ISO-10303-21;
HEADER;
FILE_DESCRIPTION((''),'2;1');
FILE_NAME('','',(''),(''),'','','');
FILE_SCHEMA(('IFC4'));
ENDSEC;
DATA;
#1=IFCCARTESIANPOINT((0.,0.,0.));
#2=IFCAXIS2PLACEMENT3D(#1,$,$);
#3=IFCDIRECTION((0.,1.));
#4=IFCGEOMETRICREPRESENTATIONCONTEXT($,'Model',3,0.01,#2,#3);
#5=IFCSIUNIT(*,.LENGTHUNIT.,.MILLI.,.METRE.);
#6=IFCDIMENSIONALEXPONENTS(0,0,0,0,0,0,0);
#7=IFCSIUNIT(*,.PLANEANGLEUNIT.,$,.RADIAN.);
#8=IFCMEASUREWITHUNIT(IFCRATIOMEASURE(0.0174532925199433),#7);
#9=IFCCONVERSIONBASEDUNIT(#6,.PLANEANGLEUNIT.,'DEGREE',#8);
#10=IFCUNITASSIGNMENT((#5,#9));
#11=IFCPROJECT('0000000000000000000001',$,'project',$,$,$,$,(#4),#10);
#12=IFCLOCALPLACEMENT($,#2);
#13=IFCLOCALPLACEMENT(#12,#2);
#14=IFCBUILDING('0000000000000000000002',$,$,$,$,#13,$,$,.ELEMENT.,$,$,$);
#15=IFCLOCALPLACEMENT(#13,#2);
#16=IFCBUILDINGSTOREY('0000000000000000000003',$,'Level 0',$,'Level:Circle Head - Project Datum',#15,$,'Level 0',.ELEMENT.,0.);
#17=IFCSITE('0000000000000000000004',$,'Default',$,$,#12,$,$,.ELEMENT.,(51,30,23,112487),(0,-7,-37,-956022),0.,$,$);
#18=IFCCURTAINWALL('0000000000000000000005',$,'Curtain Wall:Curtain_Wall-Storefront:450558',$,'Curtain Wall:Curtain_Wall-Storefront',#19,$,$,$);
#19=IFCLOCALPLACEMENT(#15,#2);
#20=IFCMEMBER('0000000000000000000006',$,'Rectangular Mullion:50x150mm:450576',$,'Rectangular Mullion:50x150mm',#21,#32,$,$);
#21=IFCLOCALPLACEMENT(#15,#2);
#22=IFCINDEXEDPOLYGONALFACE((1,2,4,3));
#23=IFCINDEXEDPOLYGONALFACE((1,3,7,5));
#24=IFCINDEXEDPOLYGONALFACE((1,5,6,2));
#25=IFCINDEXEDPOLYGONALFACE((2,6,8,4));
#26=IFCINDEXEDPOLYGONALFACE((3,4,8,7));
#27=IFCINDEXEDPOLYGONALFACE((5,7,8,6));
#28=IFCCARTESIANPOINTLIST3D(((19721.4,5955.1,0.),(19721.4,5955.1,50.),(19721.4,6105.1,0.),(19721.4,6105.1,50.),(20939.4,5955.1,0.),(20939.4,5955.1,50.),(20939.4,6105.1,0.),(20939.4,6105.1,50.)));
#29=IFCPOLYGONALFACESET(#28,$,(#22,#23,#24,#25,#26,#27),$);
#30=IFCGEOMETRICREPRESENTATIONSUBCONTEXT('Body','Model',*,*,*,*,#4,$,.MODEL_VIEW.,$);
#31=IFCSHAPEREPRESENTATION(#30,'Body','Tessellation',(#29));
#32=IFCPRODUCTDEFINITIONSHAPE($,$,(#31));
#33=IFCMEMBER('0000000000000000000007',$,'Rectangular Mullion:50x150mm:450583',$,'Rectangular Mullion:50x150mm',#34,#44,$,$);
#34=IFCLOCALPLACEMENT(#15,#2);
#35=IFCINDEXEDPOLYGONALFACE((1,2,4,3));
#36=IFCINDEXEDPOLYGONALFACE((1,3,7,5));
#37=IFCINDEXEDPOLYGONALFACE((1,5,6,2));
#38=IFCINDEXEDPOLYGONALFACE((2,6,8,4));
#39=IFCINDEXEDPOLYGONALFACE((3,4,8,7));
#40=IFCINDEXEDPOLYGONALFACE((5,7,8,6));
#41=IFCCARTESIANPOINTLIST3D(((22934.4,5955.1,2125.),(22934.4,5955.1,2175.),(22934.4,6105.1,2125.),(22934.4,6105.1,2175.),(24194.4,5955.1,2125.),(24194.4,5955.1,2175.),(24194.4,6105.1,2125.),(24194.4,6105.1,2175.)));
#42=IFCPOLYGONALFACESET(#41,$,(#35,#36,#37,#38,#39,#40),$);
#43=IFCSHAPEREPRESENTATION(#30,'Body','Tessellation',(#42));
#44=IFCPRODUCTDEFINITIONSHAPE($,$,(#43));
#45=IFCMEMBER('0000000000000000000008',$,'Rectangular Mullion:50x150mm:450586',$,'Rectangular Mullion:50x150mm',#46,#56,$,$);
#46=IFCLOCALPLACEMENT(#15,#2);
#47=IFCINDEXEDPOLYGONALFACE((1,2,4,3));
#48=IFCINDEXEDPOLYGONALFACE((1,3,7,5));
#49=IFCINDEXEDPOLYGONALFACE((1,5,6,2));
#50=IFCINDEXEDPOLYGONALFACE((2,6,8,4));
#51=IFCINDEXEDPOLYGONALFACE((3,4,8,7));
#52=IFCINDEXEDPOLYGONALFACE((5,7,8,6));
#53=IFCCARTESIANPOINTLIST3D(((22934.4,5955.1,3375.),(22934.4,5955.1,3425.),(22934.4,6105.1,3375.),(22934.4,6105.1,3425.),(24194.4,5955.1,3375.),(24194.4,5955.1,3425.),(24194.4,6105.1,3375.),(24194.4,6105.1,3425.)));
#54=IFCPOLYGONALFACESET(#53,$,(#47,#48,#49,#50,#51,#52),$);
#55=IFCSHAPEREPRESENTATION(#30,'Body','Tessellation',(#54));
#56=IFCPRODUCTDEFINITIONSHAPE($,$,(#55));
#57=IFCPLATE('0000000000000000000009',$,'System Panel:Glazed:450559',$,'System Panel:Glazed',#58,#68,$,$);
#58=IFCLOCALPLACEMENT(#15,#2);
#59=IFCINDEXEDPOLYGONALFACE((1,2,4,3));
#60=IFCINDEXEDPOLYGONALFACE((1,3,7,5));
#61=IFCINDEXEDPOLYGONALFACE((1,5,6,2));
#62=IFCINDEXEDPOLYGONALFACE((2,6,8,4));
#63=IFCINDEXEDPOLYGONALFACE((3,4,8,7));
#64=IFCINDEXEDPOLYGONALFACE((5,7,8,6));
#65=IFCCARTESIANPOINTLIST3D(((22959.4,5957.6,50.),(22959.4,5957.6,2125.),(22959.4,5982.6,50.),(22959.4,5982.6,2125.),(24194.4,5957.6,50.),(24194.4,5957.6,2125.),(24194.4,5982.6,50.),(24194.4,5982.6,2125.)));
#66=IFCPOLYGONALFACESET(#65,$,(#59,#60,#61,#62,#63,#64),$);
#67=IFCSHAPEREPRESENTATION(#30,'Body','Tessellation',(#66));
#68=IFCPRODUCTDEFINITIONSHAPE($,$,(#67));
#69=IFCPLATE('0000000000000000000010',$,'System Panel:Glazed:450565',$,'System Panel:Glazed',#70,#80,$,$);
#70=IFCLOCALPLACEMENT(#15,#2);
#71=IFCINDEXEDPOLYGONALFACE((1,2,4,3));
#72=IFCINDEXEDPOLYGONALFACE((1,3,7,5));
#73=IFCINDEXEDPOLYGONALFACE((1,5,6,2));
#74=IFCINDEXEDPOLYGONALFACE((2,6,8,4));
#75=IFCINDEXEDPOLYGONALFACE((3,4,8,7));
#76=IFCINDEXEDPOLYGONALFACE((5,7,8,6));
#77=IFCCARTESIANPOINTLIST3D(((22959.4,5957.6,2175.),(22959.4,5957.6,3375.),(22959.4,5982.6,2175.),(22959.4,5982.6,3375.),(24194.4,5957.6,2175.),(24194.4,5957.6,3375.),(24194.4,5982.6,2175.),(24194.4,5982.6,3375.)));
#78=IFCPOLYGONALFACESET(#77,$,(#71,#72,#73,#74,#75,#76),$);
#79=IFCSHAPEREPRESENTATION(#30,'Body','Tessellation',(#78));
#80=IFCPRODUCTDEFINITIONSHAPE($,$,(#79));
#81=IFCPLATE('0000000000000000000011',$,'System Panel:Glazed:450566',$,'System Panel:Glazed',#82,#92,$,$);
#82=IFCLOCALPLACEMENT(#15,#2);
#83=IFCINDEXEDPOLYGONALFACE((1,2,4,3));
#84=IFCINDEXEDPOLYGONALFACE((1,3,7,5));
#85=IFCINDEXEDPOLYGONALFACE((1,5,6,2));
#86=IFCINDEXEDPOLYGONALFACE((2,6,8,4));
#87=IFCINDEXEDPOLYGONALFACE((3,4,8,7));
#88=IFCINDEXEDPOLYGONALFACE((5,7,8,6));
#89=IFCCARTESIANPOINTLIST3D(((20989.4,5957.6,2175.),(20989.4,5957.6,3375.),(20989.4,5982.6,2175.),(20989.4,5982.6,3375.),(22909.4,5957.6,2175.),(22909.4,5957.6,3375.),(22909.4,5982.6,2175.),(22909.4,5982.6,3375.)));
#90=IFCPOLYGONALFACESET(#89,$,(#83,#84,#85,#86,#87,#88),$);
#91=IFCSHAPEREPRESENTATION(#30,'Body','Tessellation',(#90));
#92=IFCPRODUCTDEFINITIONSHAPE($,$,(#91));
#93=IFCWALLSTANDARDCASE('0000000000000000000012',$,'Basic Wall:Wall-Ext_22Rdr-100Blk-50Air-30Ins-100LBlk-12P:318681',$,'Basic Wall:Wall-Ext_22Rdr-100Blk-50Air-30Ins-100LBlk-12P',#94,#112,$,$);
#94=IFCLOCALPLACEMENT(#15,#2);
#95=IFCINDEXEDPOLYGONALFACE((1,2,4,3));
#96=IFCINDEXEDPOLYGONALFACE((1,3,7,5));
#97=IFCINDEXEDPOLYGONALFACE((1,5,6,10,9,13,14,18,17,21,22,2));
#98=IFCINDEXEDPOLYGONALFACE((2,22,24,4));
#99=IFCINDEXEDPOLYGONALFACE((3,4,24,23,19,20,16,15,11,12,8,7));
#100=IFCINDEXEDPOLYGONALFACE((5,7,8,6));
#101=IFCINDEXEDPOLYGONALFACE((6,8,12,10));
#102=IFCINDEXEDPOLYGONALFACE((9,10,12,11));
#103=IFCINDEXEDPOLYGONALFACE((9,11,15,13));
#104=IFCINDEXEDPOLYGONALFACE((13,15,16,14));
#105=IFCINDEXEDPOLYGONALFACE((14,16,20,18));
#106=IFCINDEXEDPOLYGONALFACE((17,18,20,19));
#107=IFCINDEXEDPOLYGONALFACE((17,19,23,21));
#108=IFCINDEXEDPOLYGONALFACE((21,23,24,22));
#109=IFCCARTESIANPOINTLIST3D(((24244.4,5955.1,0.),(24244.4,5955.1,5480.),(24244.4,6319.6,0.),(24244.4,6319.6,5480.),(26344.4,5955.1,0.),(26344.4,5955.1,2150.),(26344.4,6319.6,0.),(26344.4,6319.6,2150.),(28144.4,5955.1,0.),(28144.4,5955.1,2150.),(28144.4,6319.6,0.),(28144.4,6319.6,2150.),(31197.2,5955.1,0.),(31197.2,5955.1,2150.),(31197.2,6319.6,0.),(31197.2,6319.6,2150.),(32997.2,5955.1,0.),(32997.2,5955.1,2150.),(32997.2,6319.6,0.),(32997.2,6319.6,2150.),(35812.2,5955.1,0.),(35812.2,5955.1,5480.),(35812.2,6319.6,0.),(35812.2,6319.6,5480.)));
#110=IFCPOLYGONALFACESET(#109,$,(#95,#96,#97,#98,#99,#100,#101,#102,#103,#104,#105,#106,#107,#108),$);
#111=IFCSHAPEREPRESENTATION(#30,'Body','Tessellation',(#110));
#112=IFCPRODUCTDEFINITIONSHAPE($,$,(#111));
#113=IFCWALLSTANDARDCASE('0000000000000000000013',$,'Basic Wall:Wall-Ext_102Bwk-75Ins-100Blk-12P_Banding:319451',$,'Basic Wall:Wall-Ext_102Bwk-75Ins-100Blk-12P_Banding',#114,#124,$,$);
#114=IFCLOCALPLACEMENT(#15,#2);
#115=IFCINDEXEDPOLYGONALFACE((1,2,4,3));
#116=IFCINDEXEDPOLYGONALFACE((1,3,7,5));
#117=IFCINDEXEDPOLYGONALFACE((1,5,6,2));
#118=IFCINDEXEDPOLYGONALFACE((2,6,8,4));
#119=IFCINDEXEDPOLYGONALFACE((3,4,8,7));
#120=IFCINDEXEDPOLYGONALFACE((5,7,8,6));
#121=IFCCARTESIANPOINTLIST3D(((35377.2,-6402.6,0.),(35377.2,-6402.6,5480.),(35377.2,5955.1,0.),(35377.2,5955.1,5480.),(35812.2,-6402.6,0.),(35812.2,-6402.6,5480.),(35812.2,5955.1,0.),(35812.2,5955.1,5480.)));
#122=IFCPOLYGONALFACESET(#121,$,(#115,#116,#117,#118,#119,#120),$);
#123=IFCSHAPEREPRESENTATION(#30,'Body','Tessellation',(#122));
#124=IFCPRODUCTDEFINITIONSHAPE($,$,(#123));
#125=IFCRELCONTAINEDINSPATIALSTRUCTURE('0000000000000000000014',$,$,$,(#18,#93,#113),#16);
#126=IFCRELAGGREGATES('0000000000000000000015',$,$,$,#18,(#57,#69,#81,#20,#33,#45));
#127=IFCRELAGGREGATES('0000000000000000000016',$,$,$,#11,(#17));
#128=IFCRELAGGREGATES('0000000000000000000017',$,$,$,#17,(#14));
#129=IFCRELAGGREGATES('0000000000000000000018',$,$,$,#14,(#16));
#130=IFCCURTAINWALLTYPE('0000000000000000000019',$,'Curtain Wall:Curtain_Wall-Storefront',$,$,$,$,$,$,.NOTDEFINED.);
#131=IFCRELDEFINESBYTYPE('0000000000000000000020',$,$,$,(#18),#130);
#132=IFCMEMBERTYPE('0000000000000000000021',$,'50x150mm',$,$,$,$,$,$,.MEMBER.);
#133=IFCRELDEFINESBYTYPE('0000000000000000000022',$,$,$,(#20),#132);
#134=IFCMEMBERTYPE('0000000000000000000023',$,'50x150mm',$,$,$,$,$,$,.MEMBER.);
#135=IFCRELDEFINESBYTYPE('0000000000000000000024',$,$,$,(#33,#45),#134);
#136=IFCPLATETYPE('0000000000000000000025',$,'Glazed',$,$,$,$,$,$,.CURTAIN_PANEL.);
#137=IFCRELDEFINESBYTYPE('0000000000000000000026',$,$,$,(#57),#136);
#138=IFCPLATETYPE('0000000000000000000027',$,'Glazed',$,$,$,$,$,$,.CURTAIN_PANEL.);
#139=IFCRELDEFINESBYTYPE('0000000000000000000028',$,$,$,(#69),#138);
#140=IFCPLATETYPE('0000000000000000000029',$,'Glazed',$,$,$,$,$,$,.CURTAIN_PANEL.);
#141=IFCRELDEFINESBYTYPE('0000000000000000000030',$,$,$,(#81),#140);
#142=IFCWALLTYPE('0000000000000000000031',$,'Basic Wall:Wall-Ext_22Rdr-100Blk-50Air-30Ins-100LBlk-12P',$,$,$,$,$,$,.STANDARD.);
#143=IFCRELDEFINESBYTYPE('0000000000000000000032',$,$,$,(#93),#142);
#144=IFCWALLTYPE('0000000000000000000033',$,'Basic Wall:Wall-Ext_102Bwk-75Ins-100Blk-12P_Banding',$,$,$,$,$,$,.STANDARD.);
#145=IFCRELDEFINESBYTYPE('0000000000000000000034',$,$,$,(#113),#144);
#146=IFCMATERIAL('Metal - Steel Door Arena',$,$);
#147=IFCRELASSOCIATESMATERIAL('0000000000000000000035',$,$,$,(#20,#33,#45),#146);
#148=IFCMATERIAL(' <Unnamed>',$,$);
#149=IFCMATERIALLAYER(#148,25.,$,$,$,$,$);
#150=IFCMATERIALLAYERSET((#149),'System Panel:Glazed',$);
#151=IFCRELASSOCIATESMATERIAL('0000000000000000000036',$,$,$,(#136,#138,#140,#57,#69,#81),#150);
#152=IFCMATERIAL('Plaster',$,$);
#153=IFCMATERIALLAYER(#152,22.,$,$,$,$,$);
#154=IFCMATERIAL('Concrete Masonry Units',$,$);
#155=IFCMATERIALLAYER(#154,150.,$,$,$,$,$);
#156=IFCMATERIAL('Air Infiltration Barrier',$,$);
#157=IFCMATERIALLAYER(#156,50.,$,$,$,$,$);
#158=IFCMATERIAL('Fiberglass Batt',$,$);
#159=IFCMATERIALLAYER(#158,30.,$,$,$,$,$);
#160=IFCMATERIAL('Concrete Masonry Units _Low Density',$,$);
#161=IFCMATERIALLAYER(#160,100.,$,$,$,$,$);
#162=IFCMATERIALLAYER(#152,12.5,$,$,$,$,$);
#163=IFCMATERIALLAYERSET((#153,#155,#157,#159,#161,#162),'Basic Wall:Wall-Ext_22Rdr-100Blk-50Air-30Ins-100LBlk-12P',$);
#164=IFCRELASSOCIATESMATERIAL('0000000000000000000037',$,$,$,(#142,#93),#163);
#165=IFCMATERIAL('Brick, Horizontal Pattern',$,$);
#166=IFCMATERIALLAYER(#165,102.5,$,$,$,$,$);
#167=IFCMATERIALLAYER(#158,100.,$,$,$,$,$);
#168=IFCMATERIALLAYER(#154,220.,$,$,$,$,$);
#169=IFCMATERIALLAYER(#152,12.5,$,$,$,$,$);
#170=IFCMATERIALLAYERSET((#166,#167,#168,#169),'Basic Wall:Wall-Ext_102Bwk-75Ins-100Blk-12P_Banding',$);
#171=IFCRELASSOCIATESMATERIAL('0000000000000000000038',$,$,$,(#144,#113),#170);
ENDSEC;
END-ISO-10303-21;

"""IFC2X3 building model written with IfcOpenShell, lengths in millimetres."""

from ifc_helpers import new_model, entity, si_unit, converted_unit, direction, frame, frame_2d, origin, origin_2d_with_axis, place, context, subcontext, project, spatial, rectangle, extrude, source, transform, mapped, material, layer, layer_set, layer_usage, type_object, type_shapes, element, aggregate, save


model = new_model("IFC2X3")

# Units and contexts
model_context = context("Model", 3, precision=0.01, world=origin(), true_north=direction((0.0, 1.0)))
body_context = subcontext(model_context, "Body", "Model", "MODEL_VIEW")
ifc_project = project(units=[si_unit("LENGTHUNIT", "METRE", prefix="MILLI"), converted_unit("PLANEANGLEUNIT", "DEGREE", entity("IfcRatioMeasure", 0.0174532925199433), si_unit("PLANEANGLEUNIT", "RADIAN"), dimensions=[0, 0, 0, 0, 0, 0, 0])], contexts=[model_context])

# Site, building, storey
site_placement = place(None, origin())
site = spatial("IfcSite", under=ifc_project, at=site_placement, Name="Default", CompositionType="ELEMENT", RefLatitude=(51, 30, 23, 112487), RefLongitude=(0, -7, -37, -956022), RefElevation=0.0)
building_placement = place(site_placement, origin())
building = spatial("IfcBuilding", under=site, at=building_placement, CompositionType="ELEMENT")
storey_placement = place(building_placement, origin())
storey = spatial("IfcBuildingStorey", under=building, at=storey_placement, Name="Level 0", ObjectType="Level:Circle Head - Project Datum", LongName="Level 0", CompositionType="ELEMENT", Elevation=0.0)

# Curtain wall, members, plates
curtain_wall_type = type_object("IfcCurtainWallType", Name="Curtain Wall:Curtain_Wall-Storefront", PredefinedType="NOTDEFINED")
curtain_wall_placement = place(storey_placement, origin())
curtain_wall = element("IfcCurtainWall", 1, at=curtain_wall_placement, inside=storey, type_object=curtain_wall_type, Name="Curtain Wall:Curtain_Wall-Storefront:450558", ObjectType="Curtain Wall:Curtain_Wall-Storefront")
ifc_material_1 = material(Name="Metal - Steel Door Arena")
member_type_1 = type_object("IfcMemberType", Name="50x150mm", PredefinedType="MEMBER")
shared_shape_1 = source(origin(), body_context, "Body", "SweptSolid", [
    extrude(rectangle(XDim=150.0, YDim=50.0, at=origin_2d_with_axis()), frame((-25.0, 0.0, -1218.0), z_axis=(0.0, 0.0, 1.0), x_axis=(0.0, -1.0, 0.0)), (0.0, 0.0, 1.0), 1218.0),
])
type_shapes(member_type_1, [shared_shape_1])
member_1_placement = place(storey_placement, frame((20939.4, 6030.1, 0.0), z_axis=(1.0, 0.0, 0.0), x_axis=(0.0, 0.0, -1.0)))
member_1 = element("IfcMember", 2, at=member_1_placement, type_object=member_type_1, material=ifc_material_1, Name="Rectangular Mullion:50x150mm:450576", ObjectType="Rectangular Mullion:50x150mm", context=body_context, shape_type="MappedRepresentation", body=[
    mapped(shared_shape_1, transform((0.0, 0.0, 0.0), scale=1.0)),
])
member_type_2 = type_object("IfcMemberType", Name="50x150mm", PredefinedType="MEMBER")
shared_shape_2 = source(origin(), body_context, "Body", "SweptSolid", [
    extrude(rectangle(XDim=150.0, YDim=50.0, at=origin_2d_with_axis()), frame((0.0, 0.0, -1260.0), z_axis=(0.0, 0.0, 1.0), x_axis=(0.0, -1.0, 0.0)), (0.0, 0.0, 1.0), 1260.0),
])
type_shapes(member_type_2, [shared_shape_2])
member_2_placement = place(storey_placement, frame((22934.4, 6030.1, 2150.0), z_axis=(-1.0, 0.0, 0.0), x_axis=(0.0, 0.0, 1.0)))
member_2 = element("IfcMember", 3, at=member_2_placement, type_object=member_type_2, material=ifc_material_1, Name="Rectangular Mullion:50x150mm:450583", ObjectType="Rectangular Mullion:50x150mm", context=body_context, shape_type="MappedRepresentation", body=[
    mapped(shared_shape_2, transform((0.0, 0.0, 0.0), scale=1.0)),
])
member_3_placement = place(storey_placement, frame((22934.4, 6030.1, 3400.0), z_axis=(-1.0, 0.0, 0.0), x_axis=(0.0, 0.0, 1.0)))
member_3 = element("IfcMember", 4, at=member_3_placement, type_object=member_type_2, material=ifc_material_1, Name="Rectangular Mullion:50x150mm:450586", ObjectType="Rectangular Mullion:50x150mm", context=body_context, shape_type="MappedRepresentation", body=[
    mapped(shared_shape_2, transform((0.0, 0.0, 0.0), scale=1.0)),
])
ifc_material_2 = material(Name=" <Unnamed>")
ifc_layer_1 = layer(ifc_material_2, 25.0)
ifc_layer_set_1 = layer_set([ifc_layer_1], Name="System Panel:Glazed")
ifc_layer_usage_1 = layer_usage(ifc_layer_set_1, "AXIS3", "POSITIVE", 0.2)
plate_type_1 = type_object("IfcPlateType", Name="Glazed", PredefinedType="CURTAIN_PANEL", material=ifc_layer_set_1)
shared_shape_3 = source(origin(), body_context, "Body", "SweptSolid", [
    extrude(rectangle(XDim=25.0, YDim=1235.0, at=origin_2d_with_axis()), frame((0.0, 60.0, 0.0), z_axis=(0.0, 0.0, 1.0), x_axis=(0.0, 1.0, 0.0)), (0.0, 0.0, 1.0), 2075.0),
])
type_shapes(plate_type_1, [shared_shape_3])
plate_1_placement = place(curtain_wall_placement, frame((23576.9, 6030.1, 50.0), z_axis=(0.0, 0.0, 1.0), x_axis=(-1.0, 0.0, 0.0)))
plate_1 = element("IfcPlate", 5, at=plate_1_placement, type_object=plate_type_1, material=ifc_layer_usage_1, Name="System Panel:Glazed:450559", ObjectType="System Panel:Glazed", context=body_context, shape_type="MappedRepresentation", body=[
    mapped(shared_shape_3, transform((0.0, 0.0, 0.0), scale=1.0)),
])
ifc_layer_usage_2 = layer_usage(ifc_layer_set_1, "AXIS3", "POSITIVE", 0.2)
plate_type_2 = type_object("IfcPlateType", Name="Glazed", PredefinedType="CURTAIN_PANEL", material=ifc_layer_set_1)
shared_shape_4 = source(origin(), body_context, "Body", "SweptSolid", [
    extrude(rectangle(XDim=25.0, YDim=1235.0, at=origin_2d_with_axis()), frame((0.0, 60.0, 0.0), z_axis=(0.0, 0.0, 1.0), x_axis=(0.0, 1.0, 0.0)), (0.0, 0.0, 1.0), 1200.0),
])
type_shapes(plate_type_2, [shared_shape_4])
plate_2_placement = place(curtain_wall_placement, frame((23576.9, 6030.1, 2175.0), z_axis=(0.0, 0.0, 1.0), x_axis=(-1.0, 0.0, 0.0)))
plate_2 = element("IfcPlate", 6, at=plate_2_placement, type_object=plate_type_2, material=ifc_layer_usage_2, Name="System Panel:Glazed:450565", ObjectType="System Panel:Glazed", context=body_context, shape_type="MappedRepresentation", body=[
    mapped(shared_shape_4, transform((0.0, 0.0, 0.0), scale=1.0)),
])
ifc_layer_usage_3 = layer_usage(ifc_layer_set_1, "AXIS3", "POSITIVE", 0.2)
plate_type_3 = type_object("IfcPlateType", Name="Glazed", PredefinedType="CURTAIN_PANEL", material=ifc_layer_set_1)
shared_shape_5 = source(origin(), body_context, "Body", "SweptSolid", [
    extrude(rectangle(XDim=25.0, YDim=1920.0, at=origin_2d_with_axis()), frame((0.0, 60.0, 0.0), z_axis=(0.0, 0.0, 1.0), x_axis=(0.0, 1.0, 0.0)), (0.0, 0.0, 1.0), 1200.0),
])
type_shapes(plate_type_3, [shared_shape_5])
plate_3_placement = place(curtain_wall_placement, frame((21949.4, 6030.1, 2175.0), z_axis=(0.0, 0.0, 1.0), x_axis=(-1.0, 0.0, 0.0)))
plate_3 = element("IfcPlate", 7, at=plate_3_placement, type_object=plate_type_3, material=ifc_layer_usage_3, Name="System Panel:Glazed:450566", ObjectType="System Panel:Glazed", context=body_context, shape_type="MappedRepresentation", body=[
    mapped(shared_shape_5, transform((0.0, 0.0, 0.0), scale=1.0)),
])
aggregate(curtain_wall, [plate_1, plate_2, plate_3, member_1, member_2, member_3])

# Wall, openings
ifc_material_3 = material(Name="Plaster")
ifc_layer_2 = layer(ifc_material_3, 22.0)
ifc_material_4 = material(Name="Concrete Masonry Units")
ifc_layer_3 = layer(ifc_material_4, 150.0)
ifc_material_5 = material(Name="Air Infiltration Barrier")
ifc_layer_4 = layer(ifc_material_5, 50.0)
ifc_material_6 = material(Name="Fiberglass Batt")
ifc_layer_5 = layer(ifc_material_6, 30.0)
ifc_material_7 = material(Name="Concrete Masonry Units _Low Density")
ifc_layer_6 = layer(ifc_material_7, 100.0)
ifc_layer_7 = layer(ifc_material_3, 12.5)
ifc_layer_set_2 = layer_set([ifc_layer_2, ifc_layer_3, ifc_layer_4, ifc_layer_5, ifc_layer_6, ifc_layer_7], Name="Basic Wall:Wall-Ext_22Rdr-100Blk-50Air-30Ins-100LBlk-12P")
ifc_layer_usage_4 = layer_usage(ifc_layer_set_2, "AXIS2", "NEGATIVE", 182.2)
wall_type_1 = type_object("IfcWallType", Name="Basic Wall:Wall-Ext_22Rdr-100Blk-50Air-30Ins-100LBlk-12P", PredefinedType="STANDARD", material=ifc_layer_set_2)
wall_1_placement = place(storey_placement, frame((35812.2, 6137.4, 0.0), z_axis=(0.0, 0.0, 1.0), x_axis=(-1.0, 0.0, 0.0)))
wall_1 = element("IfcWallStandardCase", 8, at=wall_1_placement, inside=storey, type_object=wall_type_1, material=ifc_layer_usage_4, Name="Basic Wall:Wall-Ext_22Rdr-100Blk-50Air-30Ins-100LBlk-12P:318681", ObjectType="Basic Wall:Wall-Ext_22Rdr-100Blk-50Air-30Ins-100LBlk-12P", context=body_context, shape_type="SweptSolid", body=[
    extrude(rectangle(XDim=11567.8, YDim=364.5, at=frame_2d((5783.9, 0.0), x_axis=(-1.0, 0.0))), origin(), (0.0, 0.0, 1.0), 5480.0),
])
opening_1_placement = place(wall_1_placement, frame((9467.7, 182.2, 0.0)))
element("IfcOpeningElement", 9, at=opening_1_placement, cuts=wall_1, ObjectType="Opening", context=body_context, shape_type="SweptSolid", body=[
    extrude(rectangle(XDim=2150.0, YDim=1800.0, at=frame_2d((1075.0, 900.0), x_axis=(1.0, 0.0))), frame((0.0, 0.0, 0.0), z_axis=(0.0, -1.0, 0.0), x_axis=(0.0, 0.0, 1.0)), (0.0, 0.0, 1.0), 364.5),
])
opening_2_placement = place(wall_1_placement, frame((4615.0, 182.2, 0.0)))
element("IfcOpeningElement", 10, at=opening_2_placement, cuts=wall_1, ObjectType="Opening", context=body_context, shape_type="SweptSolid", body=[
    extrude(rectangle(XDim=2150.0, YDim=1800.0, at=frame_2d((1075.0, 900.0), x_axis=(1.0, 0.0))), frame((0.0, 0.0, 0.0), z_axis=(0.0, -1.0, 0.0), x_axis=(0.0, 0.0, 1.0)), (0.0, 0.0, 1.0), 364.5),
])

# Wall
ifc_material_8 = material(Name="Brick, Horizontal Pattern")
ifc_layer_8 = layer(ifc_material_8, 102.5)
ifc_layer_9 = layer(ifc_material_6, 100.0)
ifc_layer_10 = layer(ifc_material_4, 220.0)
ifc_layer_11 = layer(ifc_material_3, 12.5)
ifc_layer_set_3 = layer_set([ifc_layer_8, ifc_layer_9, ifc_layer_10, ifc_layer_11], Name="Basic Wall:Wall-Ext_102Bwk-75Ins-100Blk-12P_Banding")
ifc_layer_usage_5 = layer_usage(ifc_layer_set_3, "AXIS2", "NEGATIVE", 217.5)
wall_type_2 = type_object("IfcWallType", Name="Basic Wall:Wall-Ext_102Bwk-75Ins-100Blk-12P_Banding", PredefinedType="STANDARD", material=ifc_layer_set_3)
wall_2_placement = place(storey_placement, frame((35594.7, 5955.1, 0.0), z_axis=(0.0, 0.0, 1.0), x_axis=(0.0, -1.0, 0.0)))
element("IfcWallStandardCase", 11, at=wall_2_placement, inside=storey, type_object=wall_type_2, material=ifc_layer_usage_5, Name="Basic Wall:Wall-Ext_102Bwk-75Ins-100Blk-12P_Banding:319451", ObjectType="Basic Wall:Wall-Ext_102Bwk-75Ins-100Blk-12P_Banding", context=body_context, shape_type="SweptSolid", body=[
    extrude(rectangle(XDim=12357.8, YDim=435.0, at=frame_2d((6178.9, 0.0), x_axis=(-1.0, 0.0))), origin(), (0.0, 0.0, 1.0), 5480.0),
])

save(model, "model.ifc")
